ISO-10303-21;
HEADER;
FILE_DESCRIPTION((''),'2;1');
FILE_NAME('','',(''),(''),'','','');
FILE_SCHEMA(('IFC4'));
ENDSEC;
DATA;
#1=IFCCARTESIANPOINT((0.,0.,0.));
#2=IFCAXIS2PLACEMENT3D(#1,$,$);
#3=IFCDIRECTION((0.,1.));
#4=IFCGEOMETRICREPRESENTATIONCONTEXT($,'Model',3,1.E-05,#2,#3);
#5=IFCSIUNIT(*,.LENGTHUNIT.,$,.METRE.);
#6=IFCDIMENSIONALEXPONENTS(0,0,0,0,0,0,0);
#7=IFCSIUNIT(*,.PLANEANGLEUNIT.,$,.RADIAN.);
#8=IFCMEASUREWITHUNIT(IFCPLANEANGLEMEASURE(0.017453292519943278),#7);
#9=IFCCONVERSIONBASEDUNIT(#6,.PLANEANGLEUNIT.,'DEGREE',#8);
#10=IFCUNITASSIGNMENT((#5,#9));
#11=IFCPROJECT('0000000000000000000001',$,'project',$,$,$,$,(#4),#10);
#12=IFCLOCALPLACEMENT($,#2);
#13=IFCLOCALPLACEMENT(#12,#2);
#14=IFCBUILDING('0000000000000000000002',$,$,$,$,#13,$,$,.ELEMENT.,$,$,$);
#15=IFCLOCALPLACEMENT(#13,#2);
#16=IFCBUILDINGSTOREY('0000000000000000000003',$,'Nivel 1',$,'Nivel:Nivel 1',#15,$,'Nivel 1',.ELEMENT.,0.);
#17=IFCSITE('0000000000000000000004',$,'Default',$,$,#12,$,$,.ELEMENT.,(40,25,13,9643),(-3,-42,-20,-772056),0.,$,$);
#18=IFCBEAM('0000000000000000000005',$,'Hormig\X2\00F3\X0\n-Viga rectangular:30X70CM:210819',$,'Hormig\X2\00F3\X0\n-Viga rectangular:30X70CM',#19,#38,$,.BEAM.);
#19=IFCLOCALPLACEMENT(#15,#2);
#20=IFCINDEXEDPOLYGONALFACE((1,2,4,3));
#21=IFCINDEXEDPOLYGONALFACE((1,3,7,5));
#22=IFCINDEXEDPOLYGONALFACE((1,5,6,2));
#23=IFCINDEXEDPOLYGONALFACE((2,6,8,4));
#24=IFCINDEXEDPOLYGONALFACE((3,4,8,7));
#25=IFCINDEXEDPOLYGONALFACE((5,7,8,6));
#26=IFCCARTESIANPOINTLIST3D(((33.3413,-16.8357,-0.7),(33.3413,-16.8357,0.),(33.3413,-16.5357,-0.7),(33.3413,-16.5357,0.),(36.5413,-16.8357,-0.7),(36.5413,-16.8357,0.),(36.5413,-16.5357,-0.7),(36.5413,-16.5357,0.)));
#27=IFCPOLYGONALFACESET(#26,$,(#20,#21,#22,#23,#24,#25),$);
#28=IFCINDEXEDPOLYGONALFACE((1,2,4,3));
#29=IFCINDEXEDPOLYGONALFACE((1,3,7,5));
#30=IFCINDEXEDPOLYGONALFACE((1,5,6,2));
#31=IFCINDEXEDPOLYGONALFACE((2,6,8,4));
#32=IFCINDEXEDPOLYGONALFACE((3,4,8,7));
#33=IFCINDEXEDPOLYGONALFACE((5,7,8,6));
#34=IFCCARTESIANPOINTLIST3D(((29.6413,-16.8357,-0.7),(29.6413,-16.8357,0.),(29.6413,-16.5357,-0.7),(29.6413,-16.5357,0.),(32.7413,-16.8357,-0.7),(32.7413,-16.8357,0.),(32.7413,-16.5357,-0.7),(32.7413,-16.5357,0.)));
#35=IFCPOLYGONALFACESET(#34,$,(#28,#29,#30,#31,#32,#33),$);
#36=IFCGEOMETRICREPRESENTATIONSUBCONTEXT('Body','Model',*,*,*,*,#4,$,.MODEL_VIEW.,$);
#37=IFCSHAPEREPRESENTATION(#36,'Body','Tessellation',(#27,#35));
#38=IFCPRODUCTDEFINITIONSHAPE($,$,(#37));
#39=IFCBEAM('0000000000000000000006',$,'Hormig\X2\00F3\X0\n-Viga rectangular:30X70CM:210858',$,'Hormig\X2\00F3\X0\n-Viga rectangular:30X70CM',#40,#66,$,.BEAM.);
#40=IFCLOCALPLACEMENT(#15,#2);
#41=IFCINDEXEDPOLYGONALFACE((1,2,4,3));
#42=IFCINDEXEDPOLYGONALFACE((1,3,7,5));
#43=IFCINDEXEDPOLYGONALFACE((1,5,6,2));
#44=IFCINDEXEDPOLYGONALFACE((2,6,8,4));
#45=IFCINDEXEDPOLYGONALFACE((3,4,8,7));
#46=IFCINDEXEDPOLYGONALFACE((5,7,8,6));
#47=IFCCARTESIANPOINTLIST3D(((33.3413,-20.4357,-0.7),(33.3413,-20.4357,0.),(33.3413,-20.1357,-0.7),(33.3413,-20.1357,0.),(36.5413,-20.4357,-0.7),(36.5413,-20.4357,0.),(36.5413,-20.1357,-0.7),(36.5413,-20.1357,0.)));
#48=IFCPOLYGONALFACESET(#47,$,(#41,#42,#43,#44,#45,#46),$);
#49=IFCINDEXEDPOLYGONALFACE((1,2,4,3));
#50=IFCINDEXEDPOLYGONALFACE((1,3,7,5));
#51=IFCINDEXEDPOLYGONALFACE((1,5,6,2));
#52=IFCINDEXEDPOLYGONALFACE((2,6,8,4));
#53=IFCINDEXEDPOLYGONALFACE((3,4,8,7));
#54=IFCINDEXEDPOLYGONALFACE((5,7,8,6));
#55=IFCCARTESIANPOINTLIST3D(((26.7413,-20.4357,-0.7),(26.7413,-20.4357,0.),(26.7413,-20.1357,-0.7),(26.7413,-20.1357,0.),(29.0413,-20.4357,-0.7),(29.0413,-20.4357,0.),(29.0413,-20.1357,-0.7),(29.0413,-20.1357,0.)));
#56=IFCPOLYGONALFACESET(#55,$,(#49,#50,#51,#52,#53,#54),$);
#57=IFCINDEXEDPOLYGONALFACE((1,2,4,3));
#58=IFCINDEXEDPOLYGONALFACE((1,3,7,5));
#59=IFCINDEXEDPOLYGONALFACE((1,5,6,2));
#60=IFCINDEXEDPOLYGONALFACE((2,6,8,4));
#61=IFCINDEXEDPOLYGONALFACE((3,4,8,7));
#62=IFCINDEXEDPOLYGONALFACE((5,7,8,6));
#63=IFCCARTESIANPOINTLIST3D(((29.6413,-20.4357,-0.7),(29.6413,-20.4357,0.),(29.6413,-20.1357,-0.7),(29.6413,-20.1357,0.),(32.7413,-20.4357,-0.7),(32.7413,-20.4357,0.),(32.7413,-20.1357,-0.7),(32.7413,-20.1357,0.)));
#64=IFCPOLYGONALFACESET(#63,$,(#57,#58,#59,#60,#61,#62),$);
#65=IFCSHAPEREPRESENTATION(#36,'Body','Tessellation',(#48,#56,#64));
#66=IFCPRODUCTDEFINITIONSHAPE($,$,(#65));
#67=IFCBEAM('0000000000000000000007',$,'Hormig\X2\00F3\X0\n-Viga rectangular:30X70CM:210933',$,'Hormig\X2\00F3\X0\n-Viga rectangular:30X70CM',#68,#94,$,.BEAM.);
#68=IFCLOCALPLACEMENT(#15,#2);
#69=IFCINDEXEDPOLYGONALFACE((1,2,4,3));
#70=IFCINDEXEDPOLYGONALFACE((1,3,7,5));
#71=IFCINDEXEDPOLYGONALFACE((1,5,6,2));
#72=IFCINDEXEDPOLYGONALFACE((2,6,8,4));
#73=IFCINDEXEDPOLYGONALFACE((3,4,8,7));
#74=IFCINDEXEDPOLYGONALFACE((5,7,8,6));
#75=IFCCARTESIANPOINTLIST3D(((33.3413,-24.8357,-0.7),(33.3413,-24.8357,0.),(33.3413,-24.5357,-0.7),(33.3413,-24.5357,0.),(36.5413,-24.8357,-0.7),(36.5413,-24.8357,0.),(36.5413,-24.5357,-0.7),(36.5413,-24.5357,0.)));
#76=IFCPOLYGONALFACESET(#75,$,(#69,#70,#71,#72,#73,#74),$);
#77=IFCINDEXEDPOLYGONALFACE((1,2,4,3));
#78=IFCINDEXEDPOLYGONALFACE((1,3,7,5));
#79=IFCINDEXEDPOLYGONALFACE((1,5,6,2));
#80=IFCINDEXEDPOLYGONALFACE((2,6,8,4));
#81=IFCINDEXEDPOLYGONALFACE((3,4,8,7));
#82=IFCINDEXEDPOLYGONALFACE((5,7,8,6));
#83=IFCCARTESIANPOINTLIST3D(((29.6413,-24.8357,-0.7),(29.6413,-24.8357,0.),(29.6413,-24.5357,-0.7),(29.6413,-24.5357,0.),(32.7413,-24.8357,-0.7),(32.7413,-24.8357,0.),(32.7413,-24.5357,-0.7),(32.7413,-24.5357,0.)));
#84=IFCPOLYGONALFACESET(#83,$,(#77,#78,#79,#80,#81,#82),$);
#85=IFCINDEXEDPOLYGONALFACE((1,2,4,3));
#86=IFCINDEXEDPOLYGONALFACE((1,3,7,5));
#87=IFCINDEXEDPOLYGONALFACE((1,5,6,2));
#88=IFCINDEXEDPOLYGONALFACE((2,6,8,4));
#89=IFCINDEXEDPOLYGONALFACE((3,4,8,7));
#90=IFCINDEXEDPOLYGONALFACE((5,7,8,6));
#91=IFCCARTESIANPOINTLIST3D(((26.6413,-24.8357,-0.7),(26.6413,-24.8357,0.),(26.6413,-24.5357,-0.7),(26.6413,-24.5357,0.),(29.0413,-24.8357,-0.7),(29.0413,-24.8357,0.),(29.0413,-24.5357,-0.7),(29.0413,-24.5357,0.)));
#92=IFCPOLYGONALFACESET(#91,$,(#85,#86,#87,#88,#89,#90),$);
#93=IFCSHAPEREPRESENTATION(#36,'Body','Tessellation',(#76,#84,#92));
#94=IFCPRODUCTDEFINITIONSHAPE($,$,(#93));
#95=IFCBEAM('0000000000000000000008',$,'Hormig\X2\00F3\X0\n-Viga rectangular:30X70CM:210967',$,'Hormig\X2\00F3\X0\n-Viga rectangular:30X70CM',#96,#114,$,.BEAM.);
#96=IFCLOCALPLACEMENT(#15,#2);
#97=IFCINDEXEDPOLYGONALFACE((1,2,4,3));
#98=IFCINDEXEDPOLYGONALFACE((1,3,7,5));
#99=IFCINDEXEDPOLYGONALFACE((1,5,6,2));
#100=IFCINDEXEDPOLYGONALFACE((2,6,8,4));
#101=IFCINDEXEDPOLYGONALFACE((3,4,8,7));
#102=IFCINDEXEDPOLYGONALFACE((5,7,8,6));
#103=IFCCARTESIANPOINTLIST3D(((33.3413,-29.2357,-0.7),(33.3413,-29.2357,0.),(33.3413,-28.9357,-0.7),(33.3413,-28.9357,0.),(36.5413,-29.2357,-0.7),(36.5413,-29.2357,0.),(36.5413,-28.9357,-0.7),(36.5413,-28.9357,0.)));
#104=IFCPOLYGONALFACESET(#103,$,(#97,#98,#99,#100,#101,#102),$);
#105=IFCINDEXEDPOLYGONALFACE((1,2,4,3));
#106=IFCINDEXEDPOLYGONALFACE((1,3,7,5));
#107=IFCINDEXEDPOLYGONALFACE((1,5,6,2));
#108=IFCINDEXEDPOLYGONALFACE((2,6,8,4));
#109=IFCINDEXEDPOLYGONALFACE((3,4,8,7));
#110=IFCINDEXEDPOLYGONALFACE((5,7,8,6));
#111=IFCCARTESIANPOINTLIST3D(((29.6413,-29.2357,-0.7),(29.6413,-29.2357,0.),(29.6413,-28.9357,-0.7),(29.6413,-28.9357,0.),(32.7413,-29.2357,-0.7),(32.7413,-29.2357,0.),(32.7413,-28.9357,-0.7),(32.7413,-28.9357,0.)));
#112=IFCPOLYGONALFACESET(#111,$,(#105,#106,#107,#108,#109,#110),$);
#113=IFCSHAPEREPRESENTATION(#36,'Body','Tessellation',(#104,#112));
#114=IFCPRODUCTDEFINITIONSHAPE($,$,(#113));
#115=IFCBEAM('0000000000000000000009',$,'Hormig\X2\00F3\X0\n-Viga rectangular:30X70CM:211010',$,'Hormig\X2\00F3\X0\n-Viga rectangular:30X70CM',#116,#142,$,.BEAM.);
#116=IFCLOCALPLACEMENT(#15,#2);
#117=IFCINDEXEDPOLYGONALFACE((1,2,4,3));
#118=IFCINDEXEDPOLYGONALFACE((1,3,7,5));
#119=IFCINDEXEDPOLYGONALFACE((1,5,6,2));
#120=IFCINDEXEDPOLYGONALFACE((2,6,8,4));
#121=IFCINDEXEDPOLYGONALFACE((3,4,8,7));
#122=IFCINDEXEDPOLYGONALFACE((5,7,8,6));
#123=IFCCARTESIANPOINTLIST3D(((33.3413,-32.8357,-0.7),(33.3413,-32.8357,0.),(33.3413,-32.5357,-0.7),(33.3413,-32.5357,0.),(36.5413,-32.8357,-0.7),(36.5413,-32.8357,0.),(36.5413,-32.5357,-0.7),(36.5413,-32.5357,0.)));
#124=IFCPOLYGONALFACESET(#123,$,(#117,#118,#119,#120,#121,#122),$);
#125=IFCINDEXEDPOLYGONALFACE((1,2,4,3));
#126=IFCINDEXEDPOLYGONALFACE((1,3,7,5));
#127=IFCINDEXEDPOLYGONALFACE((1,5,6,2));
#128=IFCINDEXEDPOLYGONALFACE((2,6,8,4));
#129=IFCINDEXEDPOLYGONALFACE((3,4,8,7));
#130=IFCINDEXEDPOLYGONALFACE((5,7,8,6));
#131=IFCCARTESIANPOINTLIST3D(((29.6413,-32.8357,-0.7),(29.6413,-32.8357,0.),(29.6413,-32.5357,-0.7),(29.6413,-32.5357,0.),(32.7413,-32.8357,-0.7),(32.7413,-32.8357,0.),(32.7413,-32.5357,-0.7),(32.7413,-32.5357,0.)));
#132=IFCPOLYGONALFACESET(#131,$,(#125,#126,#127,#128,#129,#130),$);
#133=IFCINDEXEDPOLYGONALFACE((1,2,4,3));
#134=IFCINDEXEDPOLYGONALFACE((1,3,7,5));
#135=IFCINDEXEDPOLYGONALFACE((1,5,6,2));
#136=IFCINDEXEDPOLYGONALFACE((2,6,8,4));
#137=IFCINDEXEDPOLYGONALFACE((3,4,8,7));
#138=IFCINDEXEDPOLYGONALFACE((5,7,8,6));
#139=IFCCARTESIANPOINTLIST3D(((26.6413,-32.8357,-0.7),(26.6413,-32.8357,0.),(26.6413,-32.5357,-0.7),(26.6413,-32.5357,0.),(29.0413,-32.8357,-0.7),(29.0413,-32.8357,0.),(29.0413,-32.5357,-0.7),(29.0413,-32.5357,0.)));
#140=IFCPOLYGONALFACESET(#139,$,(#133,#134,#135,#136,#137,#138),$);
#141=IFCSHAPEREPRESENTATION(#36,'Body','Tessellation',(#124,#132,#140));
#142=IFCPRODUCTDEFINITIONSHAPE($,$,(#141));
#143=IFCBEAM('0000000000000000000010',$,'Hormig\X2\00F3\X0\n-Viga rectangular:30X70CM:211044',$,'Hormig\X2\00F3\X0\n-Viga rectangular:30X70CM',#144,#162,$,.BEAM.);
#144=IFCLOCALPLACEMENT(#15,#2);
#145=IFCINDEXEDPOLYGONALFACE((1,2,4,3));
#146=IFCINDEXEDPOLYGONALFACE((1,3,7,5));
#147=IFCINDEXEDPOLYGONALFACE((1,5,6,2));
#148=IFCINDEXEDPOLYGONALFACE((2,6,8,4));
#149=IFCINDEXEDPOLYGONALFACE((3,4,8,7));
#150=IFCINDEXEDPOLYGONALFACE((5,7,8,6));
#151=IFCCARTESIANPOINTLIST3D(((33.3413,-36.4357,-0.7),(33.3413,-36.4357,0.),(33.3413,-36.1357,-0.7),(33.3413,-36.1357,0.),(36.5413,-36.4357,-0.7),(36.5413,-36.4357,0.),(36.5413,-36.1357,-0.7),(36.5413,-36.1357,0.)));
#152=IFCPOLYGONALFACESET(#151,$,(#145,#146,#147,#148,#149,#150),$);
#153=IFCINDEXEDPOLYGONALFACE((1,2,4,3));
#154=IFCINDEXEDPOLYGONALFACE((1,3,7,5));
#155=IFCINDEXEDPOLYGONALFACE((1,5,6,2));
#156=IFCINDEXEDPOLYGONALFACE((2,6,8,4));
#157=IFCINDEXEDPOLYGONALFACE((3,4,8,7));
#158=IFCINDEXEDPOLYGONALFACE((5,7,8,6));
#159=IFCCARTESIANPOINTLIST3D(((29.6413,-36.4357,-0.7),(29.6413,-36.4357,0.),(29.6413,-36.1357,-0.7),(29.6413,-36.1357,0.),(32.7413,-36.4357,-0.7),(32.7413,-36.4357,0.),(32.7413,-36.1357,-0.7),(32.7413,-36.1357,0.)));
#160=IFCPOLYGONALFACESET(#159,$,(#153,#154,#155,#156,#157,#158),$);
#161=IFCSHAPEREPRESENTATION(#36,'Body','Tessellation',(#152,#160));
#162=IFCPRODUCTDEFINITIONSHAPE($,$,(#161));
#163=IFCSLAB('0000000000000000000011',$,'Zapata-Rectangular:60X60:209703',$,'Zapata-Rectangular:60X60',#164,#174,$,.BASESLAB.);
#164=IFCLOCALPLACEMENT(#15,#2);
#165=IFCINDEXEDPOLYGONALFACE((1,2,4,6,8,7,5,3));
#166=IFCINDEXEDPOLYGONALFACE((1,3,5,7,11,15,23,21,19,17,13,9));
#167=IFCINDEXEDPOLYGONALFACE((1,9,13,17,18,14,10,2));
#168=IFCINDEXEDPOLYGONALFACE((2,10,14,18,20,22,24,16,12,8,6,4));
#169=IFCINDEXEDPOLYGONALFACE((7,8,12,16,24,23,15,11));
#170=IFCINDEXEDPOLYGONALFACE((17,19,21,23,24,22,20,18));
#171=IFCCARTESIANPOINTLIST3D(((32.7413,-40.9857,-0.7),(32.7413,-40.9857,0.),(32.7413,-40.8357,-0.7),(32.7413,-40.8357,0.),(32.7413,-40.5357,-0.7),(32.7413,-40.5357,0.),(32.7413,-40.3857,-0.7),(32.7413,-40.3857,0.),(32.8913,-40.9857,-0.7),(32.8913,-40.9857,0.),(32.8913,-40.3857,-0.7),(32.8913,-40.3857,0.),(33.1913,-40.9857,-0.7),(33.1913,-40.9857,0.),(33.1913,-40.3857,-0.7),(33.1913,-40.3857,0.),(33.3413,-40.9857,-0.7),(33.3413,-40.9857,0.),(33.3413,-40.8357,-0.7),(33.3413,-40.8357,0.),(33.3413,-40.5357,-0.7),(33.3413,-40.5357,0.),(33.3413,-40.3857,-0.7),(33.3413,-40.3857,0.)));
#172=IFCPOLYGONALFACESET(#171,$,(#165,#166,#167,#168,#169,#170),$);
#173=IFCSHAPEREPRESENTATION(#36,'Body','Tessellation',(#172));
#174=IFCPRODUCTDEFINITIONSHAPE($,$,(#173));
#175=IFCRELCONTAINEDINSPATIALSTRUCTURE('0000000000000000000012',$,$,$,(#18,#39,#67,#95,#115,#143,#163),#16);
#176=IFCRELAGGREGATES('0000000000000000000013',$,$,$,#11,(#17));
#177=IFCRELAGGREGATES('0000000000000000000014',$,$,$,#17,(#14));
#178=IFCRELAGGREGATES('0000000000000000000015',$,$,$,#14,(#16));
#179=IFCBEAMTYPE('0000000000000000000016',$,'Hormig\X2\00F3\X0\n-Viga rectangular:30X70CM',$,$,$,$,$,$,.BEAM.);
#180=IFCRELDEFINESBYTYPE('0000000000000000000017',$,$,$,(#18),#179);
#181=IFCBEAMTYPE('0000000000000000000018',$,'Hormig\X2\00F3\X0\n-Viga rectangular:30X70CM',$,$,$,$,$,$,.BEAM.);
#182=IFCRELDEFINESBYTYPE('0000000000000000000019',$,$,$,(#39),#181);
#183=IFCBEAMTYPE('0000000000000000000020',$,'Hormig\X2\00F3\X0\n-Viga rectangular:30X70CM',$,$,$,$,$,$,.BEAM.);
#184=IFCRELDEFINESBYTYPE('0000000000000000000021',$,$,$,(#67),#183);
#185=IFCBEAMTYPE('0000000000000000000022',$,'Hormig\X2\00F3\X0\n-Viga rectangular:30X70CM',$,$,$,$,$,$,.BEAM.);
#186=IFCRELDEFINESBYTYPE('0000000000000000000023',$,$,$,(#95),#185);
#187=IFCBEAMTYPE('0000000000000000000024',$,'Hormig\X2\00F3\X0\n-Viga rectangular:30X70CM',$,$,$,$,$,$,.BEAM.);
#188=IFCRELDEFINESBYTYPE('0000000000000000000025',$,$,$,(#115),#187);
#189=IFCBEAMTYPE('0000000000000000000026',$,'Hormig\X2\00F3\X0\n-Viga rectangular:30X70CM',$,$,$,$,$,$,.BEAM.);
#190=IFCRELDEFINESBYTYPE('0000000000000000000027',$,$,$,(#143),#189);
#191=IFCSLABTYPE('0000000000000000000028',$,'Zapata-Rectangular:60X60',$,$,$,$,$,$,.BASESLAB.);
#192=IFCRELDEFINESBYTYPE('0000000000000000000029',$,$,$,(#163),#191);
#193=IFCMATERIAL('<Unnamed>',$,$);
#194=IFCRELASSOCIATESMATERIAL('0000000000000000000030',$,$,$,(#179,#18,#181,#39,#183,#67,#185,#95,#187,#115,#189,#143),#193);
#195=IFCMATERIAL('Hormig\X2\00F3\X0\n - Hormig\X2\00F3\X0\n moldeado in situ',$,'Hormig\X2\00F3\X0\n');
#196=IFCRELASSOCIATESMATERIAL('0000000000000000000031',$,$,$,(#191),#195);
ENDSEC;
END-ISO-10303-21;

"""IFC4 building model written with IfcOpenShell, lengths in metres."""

from ifc_helpers import new_model, entity, si_unit, converted_unit, direction, frame, origin, place, context, subcontext, project, spatial, indexed_curve, outline, extrude, source, transform, mapped, material, type_object, type_shapes, element, save


model = new_model("IFC4")

# Units and contexts
model_context = context("Model", 3, precision=1e-05, world=origin(), true_north=direction((0.0, 1.0)))
body_context = subcontext(model_context, "Body", "Model", "MODEL_VIEW")
ifc_project = project(units=[si_unit("LENGTHUNIT", "METRE"), converted_unit("PLANEANGLEUNIT", "DEGREE", entity("IfcPlaneAngleMeasure", 0.017453292519943278), si_unit("PLANEANGLEUNIT", "RADIAN"), dimensions=[0, 0, 0, 0, 0, 0, 0])], contexts=[model_context])

# Site, building, storey
site_placement = place(None, origin())
site = spatial("IfcSite", under=ifc_project, at=site_placement, Name="Default", CompositionType="ELEMENT", RefLatitude=(40, 25, 13, 9643), RefLongitude=(-3, -42, -20, -772056), RefElevation=0.0)
building_placement = place(site_placement, origin())
building = spatial("IfcBuilding", under=site, at=building_placement, CompositionType="ELEMENT")
storey_placement = place(building_placement, origin())
storey = spatial("IfcBuildingStorey", under=building, at=storey_placement, Name="Nivel 1", ObjectType="Nivel:Nivel 1", LongName="Nivel 1", CompositionType="ELEMENT", Elevation=0.0)

# Beams
ifc_material_1 = material(Name="<Unnamed>")
beam_type_1 = type_object("IfcBeamType", Name="Hormigón-Viga rectangular:30X70CM", PredefinedType="BEAM", material=ifc_material_1)
shared_shape_1 = source(origin(), body_context, "Body", "SweptSolid", [
    extrude(outline(indexed_curve([(-0.35, -0.15), (0.35, -0.15), (0.35, 0.15), (-0.35, 0.15), (-0.35, -0.15)], self_intersect=False)), frame((36.5413, -16.6857, -0.35), z_axis=(-1.0, 0.0, 0.0), x_axis=(0.0, 0.0, -1.0)), (0.0, 0.0, 1.0), 3.2),
    extrude(outline(indexed_curve([(-0.35, -0.15), (0.35, -0.15), (0.35, 0.15), (-0.35, 0.15), (-0.35, -0.15)], self_intersect=False)), frame((32.7413, -16.6857, -0.35), z_axis=(-1.0, 0.0, 0.0), x_axis=(0.0, 0.0, -1.0)), (0.0, 0.0, 1.0), 3.1),
])
type_shapes(beam_type_1, [shared_shape_1])
beam_1_placement = place(storey_placement, origin())
element("IfcBeam", 1, at=beam_1_placement, inside=storey, type_object=beam_type_1, material=ifc_material_1, Name="Hormigón-Viga rectangular:30X70CM:210819", ObjectType="Hormigón-Viga rectangular:30X70CM", PredefinedType="BEAM", context=body_context, shape_type="MappedRepresentation", body=[
    mapped(shared_shape_1, transform((0.0, 0.0, 0.0), scale=1.0)),
])
beam_type_2 = type_object("IfcBeamType", Name="Hormigón-Viga rectangular:30X70CM", PredefinedType="BEAM", material=ifc_material_1)
shared_shape_2 = source(origin(), body_context, "Body", "SweptSolid", [
    extrude(outline(indexed_curve([(-0.35, -0.15), (0.35, -0.15), (0.35, 0.15), (-0.35, 0.15), (-0.35, -0.15)], self_intersect=False)), frame((36.5413, -20.2857, -0.35), z_axis=(-1.0, 0.0, 0.0), x_axis=(0.0, 0.0, -1.0)), (0.0, 0.0, 1.0), 3.2),
    extrude(outline(indexed_curve([(-0.35, -0.15), (0.35, -0.15), (0.35, 0.15), (-0.35, 0.15), (-0.35, -0.15)], self_intersect=False)), frame((29.0413, -20.2857, -0.35), z_axis=(-1.0, 0.0, 0.0), x_axis=(0.0, 0.0, -1.0)), (0.0, 0.0, 1.0), 2.3),
    extrude(outline(indexed_curve([(-0.35, -0.15), (0.35, -0.15), (0.35, 0.15), (-0.35, 0.15), (-0.35, -0.15)], self_intersect=False)), frame((32.7413, -20.2857, -0.35), z_axis=(-1.0, 0.0, 0.0), x_axis=(0.0, 0.0, -1.0)), (0.0, 0.0, 1.0), 3.1),
])
type_shapes(beam_type_2, [shared_shape_2])
beam_2_placement = place(storey_placement, origin())
element("IfcBeam", 2, at=beam_2_placement, inside=storey, type_object=beam_type_2, material=ifc_material_1, Name="Hormigón-Viga rectangular:30X70CM:210858", ObjectType="Hormigón-Viga rectangular:30X70CM", PredefinedType="BEAM", context=body_context, shape_type="MappedRepresentation", body=[
    mapped(shared_shape_2, transform((0.0, 0.0, 0.0), scale=1.0)),
])
beam_type_3 = type_object("IfcBeamType", Name="Hormigón-Viga rectangular:30X70CM", PredefinedType="BEAM", material=ifc_material_1)
shared_shape_3 = source(origin(), body_context, "Body", "SweptSolid", [
    extrude(outline(indexed_curve([(-0.35, -0.15), (0.35, -0.15), (0.35, 0.15), (-0.35, 0.15), (-0.35, -0.15)], self_intersect=False)), frame((36.5413, -24.6857, -0.35), z_axis=(-1.0, 0.0, 0.0), x_axis=(0.0, 0.0, -1.0)), (0.0, 0.0, 1.0), 3.2),
    extrude(outline(indexed_curve([(-0.35, -0.15), (0.35, -0.15), (0.35, 0.15), (-0.35, 0.15), (-0.35, -0.15)], self_intersect=False)), frame((32.7413, -24.6857, -0.35), z_axis=(-1.0, 0.0, 0.0), x_axis=(0.0, 0.0, -1.0)), (0.0, 0.0, 1.0), 3.1),
    extrude(outline(indexed_curve([(-0.35, -0.15), (0.35, -0.15), (0.35, 0.15), (-0.35, 0.15), (-0.35, -0.15)], self_intersect=False)), frame((29.0413, -24.6857, -0.35), z_axis=(-1.0, 0.0, 0.0), x_axis=(0.0, 0.0, -1.0)), (0.0, 0.0, 1.0), 2.4),
])
type_shapes(beam_type_3, [shared_shape_3])
beam_3_placement = place(storey_placement, origin())
element("IfcBeam", 3, at=beam_3_placement, inside=storey, type_object=beam_type_3, material=ifc_material_1, Name="Hormigón-Viga rectangular:30X70CM:210933", ObjectType="Hormigón-Viga rectangular:30X70CM", PredefinedType="BEAM", context=body_context, shape_type="MappedRepresentation", body=[
    mapped(shared_shape_3, transform((0.0, 0.0, 0.0), scale=1.0)),
])
beam_type_4 = type_object("IfcBeamType", Name="Hormigón-Viga rectangular:30X70CM", PredefinedType="BEAM", material=ifc_material_1)
shared_shape_4 = source(origin(), body_context, "Body", "SweptSolid", [
    extrude(outline(indexed_curve([(-0.35, -0.15), (0.35, -0.15), (0.35, 0.15), (-0.35, 0.15), (-0.35, -0.15)], self_intersect=False)), frame((36.5413, -29.0857, -0.35), z_axis=(-1.0, 0.0, 0.0), x_axis=(0.0, 0.0, -1.0)), (0.0, 0.0, 1.0), 3.2),
    extrude(outline(indexed_curve([(-0.35, -0.15), (0.35, -0.15), (0.35, 0.15), (-0.35, 0.15), (-0.35, -0.15)], self_intersect=False)), frame((32.7413, -29.0857, -0.35), z_axis=(-1.0, 0.0, 0.0), x_axis=(0.0, 0.0, -1.0)), (0.0, 0.0, 1.0), 3.1),
])
type_shapes(beam_type_4, [shared_shape_4])
beam_4_placement = place(storey_placement, origin())
element("IfcBeam", 4, at=beam_4_placement, inside=storey, type_object=beam_type_4, material=ifc_material_1, Name="Hormigón-Viga rectangular:30X70CM:210967", ObjectType="Hormigón-Viga rectangular:30X70CM", PredefinedType="BEAM", context=body_context, shape_type="MappedRepresentation", body=[
    mapped(shared_shape_4, transform((0.0, 0.0, 0.0), scale=1.0)),
])
beam_type_5 = type_object("IfcBeamType", Name="Hormigón-Viga rectangular:30X70CM", PredefinedType="BEAM", material=ifc_material_1)
shared_shape_5 = source(origin(), body_context, "Body", "SweptSolid", [
    extrude(outline(indexed_curve([(-0.35, -0.15), (0.35, -0.15), (0.35, 0.15), (-0.35, 0.15), (-0.35, -0.15)], self_intersect=False)), frame((36.5413, -32.6857, -0.35), z_axis=(-1.0, 0.0, 0.0), x_axis=(0.0, 0.0, -1.0)), (0.0, 0.0, 1.0), 3.2),
    extrude(outline(indexed_curve([(-0.35, -0.15), (0.35, -0.15), (0.35, 0.15), (-0.35, 0.15), (-0.35, -0.15)], self_intersect=False)), frame((32.7413, -32.6857, -0.35), z_axis=(-1.0, 0.0, 0.0), x_axis=(0.0, 0.0, -1.0)), (0.0, 0.0, 1.0), 3.1),
    extrude(outline(indexed_curve([(-0.35, -0.15), (0.35, -0.15), (0.35, 0.15), (-0.35, 0.15), (-0.35, -0.15)], self_intersect=False)), frame((29.0413, -32.6857, -0.35), z_axis=(-1.0, 0.0, 0.0), x_axis=(0.0, 0.0, -1.0)), (0.0, 0.0, 1.0), 2.4),
])
type_shapes(beam_type_5, [shared_shape_5])
beam_5_placement = place(storey_placement, origin())
element("IfcBeam", 5, at=beam_5_placement, inside=storey, type_object=beam_type_5, material=ifc_material_1, Name="Hormigón-Viga rectangular:30X70CM:211010", ObjectType="Hormigón-Viga rectangular:30X70CM", PredefinedType="BEAM", context=body_context, shape_type="MappedRepresentation", body=[
    mapped(shared_shape_5, transform((0.0, 0.0, 0.0), scale=1.0)),
])
beam_type_6 = type_object("IfcBeamType", Name="Hormigón-Viga rectangular:30X70CM", PredefinedType="BEAM", material=ifc_material_1)
shared_shape_6 = source(origin(), body_context, "Body", "SweptSolid", [
    extrude(outline(indexed_curve([(-0.35, -0.15), (0.35, -0.15), (0.35, 0.15), (-0.35, 0.15), (-0.35, -0.15)], self_intersect=False)), frame((36.5413, -36.2857, -0.35), z_axis=(-1.0, 0.0, 0.0), x_axis=(0.0, 0.0, -1.0)), (0.0, 0.0, 1.0), 3.2),
    extrude(outline(indexed_curve([(-0.35, -0.15), (0.35, -0.15), (0.35, 0.15), (-0.35, 0.15), (-0.35, -0.15)], self_intersect=False)), frame((32.7413, -36.2857, -0.35), z_axis=(-1.0, 0.0, 0.0), x_axis=(0.0, 0.0, -1.0)), (0.0, 0.0, 1.0), 3.1),
])
type_shapes(beam_type_6, [shared_shape_6])
beam_6_placement = place(storey_placement, origin())
element("IfcBeam", 6, at=beam_6_placement, inside=storey, type_object=beam_type_6, material=ifc_material_1, Name="Hormigón-Viga rectangular:30X70CM:211044", ObjectType="Hormigón-Viga rectangular:30X70CM", PredefinedType="BEAM", context=body_context, shape_type="MappedRepresentation", body=[
    mapped(shared_shape_6, transform((0.0, 0.0, 0.0), scale=1.0)),
])

# Slab
ifc_material_2 = material(Name="Hormigón - Hormigón moldeado in situ", Category="Hormigón")
slab_type = type_object("IfcSlabType", Name="Zapata-Rectangular:60X60", PredefinedType="BASESLAB", material=ifc_material_2)
slab_1_placement = place(storey_placement, origin())
element("IfcSlab", 7, at=slab_1_placement, inside=storey, type_object=slab_type, Name="Zapata-Rectangular:60X60:209703", ObjectType="Zapata-Rectangular:60X60", PredefinedType="BASESLAB", context=body_context, shape_type="SweptSolid", body=[
    extrude(outline(indexed_curve([(-0.3, -0.3), (-0.15, -0.3), (0.15, -0.3), (0.3, -0.3), (0.3, -0.15), (0.3, 0.15), (0.3, 0.3), (0.15, 0.3), (-0.15, 0.3), (-0.3, 0.3), (-0.3, 0.15), (-0.3, -0.15), (-0.3, -0.3)], self_intersect=False)), frame((33.0413, -40.6857, -0.7), z_axis=(0.0, 0.0, 1.0), x_axis=(-1.0, 0.0, 0.0)), (0.0, 0.0, 1.0), 0.7),
])

save(model, "model.ifc")
